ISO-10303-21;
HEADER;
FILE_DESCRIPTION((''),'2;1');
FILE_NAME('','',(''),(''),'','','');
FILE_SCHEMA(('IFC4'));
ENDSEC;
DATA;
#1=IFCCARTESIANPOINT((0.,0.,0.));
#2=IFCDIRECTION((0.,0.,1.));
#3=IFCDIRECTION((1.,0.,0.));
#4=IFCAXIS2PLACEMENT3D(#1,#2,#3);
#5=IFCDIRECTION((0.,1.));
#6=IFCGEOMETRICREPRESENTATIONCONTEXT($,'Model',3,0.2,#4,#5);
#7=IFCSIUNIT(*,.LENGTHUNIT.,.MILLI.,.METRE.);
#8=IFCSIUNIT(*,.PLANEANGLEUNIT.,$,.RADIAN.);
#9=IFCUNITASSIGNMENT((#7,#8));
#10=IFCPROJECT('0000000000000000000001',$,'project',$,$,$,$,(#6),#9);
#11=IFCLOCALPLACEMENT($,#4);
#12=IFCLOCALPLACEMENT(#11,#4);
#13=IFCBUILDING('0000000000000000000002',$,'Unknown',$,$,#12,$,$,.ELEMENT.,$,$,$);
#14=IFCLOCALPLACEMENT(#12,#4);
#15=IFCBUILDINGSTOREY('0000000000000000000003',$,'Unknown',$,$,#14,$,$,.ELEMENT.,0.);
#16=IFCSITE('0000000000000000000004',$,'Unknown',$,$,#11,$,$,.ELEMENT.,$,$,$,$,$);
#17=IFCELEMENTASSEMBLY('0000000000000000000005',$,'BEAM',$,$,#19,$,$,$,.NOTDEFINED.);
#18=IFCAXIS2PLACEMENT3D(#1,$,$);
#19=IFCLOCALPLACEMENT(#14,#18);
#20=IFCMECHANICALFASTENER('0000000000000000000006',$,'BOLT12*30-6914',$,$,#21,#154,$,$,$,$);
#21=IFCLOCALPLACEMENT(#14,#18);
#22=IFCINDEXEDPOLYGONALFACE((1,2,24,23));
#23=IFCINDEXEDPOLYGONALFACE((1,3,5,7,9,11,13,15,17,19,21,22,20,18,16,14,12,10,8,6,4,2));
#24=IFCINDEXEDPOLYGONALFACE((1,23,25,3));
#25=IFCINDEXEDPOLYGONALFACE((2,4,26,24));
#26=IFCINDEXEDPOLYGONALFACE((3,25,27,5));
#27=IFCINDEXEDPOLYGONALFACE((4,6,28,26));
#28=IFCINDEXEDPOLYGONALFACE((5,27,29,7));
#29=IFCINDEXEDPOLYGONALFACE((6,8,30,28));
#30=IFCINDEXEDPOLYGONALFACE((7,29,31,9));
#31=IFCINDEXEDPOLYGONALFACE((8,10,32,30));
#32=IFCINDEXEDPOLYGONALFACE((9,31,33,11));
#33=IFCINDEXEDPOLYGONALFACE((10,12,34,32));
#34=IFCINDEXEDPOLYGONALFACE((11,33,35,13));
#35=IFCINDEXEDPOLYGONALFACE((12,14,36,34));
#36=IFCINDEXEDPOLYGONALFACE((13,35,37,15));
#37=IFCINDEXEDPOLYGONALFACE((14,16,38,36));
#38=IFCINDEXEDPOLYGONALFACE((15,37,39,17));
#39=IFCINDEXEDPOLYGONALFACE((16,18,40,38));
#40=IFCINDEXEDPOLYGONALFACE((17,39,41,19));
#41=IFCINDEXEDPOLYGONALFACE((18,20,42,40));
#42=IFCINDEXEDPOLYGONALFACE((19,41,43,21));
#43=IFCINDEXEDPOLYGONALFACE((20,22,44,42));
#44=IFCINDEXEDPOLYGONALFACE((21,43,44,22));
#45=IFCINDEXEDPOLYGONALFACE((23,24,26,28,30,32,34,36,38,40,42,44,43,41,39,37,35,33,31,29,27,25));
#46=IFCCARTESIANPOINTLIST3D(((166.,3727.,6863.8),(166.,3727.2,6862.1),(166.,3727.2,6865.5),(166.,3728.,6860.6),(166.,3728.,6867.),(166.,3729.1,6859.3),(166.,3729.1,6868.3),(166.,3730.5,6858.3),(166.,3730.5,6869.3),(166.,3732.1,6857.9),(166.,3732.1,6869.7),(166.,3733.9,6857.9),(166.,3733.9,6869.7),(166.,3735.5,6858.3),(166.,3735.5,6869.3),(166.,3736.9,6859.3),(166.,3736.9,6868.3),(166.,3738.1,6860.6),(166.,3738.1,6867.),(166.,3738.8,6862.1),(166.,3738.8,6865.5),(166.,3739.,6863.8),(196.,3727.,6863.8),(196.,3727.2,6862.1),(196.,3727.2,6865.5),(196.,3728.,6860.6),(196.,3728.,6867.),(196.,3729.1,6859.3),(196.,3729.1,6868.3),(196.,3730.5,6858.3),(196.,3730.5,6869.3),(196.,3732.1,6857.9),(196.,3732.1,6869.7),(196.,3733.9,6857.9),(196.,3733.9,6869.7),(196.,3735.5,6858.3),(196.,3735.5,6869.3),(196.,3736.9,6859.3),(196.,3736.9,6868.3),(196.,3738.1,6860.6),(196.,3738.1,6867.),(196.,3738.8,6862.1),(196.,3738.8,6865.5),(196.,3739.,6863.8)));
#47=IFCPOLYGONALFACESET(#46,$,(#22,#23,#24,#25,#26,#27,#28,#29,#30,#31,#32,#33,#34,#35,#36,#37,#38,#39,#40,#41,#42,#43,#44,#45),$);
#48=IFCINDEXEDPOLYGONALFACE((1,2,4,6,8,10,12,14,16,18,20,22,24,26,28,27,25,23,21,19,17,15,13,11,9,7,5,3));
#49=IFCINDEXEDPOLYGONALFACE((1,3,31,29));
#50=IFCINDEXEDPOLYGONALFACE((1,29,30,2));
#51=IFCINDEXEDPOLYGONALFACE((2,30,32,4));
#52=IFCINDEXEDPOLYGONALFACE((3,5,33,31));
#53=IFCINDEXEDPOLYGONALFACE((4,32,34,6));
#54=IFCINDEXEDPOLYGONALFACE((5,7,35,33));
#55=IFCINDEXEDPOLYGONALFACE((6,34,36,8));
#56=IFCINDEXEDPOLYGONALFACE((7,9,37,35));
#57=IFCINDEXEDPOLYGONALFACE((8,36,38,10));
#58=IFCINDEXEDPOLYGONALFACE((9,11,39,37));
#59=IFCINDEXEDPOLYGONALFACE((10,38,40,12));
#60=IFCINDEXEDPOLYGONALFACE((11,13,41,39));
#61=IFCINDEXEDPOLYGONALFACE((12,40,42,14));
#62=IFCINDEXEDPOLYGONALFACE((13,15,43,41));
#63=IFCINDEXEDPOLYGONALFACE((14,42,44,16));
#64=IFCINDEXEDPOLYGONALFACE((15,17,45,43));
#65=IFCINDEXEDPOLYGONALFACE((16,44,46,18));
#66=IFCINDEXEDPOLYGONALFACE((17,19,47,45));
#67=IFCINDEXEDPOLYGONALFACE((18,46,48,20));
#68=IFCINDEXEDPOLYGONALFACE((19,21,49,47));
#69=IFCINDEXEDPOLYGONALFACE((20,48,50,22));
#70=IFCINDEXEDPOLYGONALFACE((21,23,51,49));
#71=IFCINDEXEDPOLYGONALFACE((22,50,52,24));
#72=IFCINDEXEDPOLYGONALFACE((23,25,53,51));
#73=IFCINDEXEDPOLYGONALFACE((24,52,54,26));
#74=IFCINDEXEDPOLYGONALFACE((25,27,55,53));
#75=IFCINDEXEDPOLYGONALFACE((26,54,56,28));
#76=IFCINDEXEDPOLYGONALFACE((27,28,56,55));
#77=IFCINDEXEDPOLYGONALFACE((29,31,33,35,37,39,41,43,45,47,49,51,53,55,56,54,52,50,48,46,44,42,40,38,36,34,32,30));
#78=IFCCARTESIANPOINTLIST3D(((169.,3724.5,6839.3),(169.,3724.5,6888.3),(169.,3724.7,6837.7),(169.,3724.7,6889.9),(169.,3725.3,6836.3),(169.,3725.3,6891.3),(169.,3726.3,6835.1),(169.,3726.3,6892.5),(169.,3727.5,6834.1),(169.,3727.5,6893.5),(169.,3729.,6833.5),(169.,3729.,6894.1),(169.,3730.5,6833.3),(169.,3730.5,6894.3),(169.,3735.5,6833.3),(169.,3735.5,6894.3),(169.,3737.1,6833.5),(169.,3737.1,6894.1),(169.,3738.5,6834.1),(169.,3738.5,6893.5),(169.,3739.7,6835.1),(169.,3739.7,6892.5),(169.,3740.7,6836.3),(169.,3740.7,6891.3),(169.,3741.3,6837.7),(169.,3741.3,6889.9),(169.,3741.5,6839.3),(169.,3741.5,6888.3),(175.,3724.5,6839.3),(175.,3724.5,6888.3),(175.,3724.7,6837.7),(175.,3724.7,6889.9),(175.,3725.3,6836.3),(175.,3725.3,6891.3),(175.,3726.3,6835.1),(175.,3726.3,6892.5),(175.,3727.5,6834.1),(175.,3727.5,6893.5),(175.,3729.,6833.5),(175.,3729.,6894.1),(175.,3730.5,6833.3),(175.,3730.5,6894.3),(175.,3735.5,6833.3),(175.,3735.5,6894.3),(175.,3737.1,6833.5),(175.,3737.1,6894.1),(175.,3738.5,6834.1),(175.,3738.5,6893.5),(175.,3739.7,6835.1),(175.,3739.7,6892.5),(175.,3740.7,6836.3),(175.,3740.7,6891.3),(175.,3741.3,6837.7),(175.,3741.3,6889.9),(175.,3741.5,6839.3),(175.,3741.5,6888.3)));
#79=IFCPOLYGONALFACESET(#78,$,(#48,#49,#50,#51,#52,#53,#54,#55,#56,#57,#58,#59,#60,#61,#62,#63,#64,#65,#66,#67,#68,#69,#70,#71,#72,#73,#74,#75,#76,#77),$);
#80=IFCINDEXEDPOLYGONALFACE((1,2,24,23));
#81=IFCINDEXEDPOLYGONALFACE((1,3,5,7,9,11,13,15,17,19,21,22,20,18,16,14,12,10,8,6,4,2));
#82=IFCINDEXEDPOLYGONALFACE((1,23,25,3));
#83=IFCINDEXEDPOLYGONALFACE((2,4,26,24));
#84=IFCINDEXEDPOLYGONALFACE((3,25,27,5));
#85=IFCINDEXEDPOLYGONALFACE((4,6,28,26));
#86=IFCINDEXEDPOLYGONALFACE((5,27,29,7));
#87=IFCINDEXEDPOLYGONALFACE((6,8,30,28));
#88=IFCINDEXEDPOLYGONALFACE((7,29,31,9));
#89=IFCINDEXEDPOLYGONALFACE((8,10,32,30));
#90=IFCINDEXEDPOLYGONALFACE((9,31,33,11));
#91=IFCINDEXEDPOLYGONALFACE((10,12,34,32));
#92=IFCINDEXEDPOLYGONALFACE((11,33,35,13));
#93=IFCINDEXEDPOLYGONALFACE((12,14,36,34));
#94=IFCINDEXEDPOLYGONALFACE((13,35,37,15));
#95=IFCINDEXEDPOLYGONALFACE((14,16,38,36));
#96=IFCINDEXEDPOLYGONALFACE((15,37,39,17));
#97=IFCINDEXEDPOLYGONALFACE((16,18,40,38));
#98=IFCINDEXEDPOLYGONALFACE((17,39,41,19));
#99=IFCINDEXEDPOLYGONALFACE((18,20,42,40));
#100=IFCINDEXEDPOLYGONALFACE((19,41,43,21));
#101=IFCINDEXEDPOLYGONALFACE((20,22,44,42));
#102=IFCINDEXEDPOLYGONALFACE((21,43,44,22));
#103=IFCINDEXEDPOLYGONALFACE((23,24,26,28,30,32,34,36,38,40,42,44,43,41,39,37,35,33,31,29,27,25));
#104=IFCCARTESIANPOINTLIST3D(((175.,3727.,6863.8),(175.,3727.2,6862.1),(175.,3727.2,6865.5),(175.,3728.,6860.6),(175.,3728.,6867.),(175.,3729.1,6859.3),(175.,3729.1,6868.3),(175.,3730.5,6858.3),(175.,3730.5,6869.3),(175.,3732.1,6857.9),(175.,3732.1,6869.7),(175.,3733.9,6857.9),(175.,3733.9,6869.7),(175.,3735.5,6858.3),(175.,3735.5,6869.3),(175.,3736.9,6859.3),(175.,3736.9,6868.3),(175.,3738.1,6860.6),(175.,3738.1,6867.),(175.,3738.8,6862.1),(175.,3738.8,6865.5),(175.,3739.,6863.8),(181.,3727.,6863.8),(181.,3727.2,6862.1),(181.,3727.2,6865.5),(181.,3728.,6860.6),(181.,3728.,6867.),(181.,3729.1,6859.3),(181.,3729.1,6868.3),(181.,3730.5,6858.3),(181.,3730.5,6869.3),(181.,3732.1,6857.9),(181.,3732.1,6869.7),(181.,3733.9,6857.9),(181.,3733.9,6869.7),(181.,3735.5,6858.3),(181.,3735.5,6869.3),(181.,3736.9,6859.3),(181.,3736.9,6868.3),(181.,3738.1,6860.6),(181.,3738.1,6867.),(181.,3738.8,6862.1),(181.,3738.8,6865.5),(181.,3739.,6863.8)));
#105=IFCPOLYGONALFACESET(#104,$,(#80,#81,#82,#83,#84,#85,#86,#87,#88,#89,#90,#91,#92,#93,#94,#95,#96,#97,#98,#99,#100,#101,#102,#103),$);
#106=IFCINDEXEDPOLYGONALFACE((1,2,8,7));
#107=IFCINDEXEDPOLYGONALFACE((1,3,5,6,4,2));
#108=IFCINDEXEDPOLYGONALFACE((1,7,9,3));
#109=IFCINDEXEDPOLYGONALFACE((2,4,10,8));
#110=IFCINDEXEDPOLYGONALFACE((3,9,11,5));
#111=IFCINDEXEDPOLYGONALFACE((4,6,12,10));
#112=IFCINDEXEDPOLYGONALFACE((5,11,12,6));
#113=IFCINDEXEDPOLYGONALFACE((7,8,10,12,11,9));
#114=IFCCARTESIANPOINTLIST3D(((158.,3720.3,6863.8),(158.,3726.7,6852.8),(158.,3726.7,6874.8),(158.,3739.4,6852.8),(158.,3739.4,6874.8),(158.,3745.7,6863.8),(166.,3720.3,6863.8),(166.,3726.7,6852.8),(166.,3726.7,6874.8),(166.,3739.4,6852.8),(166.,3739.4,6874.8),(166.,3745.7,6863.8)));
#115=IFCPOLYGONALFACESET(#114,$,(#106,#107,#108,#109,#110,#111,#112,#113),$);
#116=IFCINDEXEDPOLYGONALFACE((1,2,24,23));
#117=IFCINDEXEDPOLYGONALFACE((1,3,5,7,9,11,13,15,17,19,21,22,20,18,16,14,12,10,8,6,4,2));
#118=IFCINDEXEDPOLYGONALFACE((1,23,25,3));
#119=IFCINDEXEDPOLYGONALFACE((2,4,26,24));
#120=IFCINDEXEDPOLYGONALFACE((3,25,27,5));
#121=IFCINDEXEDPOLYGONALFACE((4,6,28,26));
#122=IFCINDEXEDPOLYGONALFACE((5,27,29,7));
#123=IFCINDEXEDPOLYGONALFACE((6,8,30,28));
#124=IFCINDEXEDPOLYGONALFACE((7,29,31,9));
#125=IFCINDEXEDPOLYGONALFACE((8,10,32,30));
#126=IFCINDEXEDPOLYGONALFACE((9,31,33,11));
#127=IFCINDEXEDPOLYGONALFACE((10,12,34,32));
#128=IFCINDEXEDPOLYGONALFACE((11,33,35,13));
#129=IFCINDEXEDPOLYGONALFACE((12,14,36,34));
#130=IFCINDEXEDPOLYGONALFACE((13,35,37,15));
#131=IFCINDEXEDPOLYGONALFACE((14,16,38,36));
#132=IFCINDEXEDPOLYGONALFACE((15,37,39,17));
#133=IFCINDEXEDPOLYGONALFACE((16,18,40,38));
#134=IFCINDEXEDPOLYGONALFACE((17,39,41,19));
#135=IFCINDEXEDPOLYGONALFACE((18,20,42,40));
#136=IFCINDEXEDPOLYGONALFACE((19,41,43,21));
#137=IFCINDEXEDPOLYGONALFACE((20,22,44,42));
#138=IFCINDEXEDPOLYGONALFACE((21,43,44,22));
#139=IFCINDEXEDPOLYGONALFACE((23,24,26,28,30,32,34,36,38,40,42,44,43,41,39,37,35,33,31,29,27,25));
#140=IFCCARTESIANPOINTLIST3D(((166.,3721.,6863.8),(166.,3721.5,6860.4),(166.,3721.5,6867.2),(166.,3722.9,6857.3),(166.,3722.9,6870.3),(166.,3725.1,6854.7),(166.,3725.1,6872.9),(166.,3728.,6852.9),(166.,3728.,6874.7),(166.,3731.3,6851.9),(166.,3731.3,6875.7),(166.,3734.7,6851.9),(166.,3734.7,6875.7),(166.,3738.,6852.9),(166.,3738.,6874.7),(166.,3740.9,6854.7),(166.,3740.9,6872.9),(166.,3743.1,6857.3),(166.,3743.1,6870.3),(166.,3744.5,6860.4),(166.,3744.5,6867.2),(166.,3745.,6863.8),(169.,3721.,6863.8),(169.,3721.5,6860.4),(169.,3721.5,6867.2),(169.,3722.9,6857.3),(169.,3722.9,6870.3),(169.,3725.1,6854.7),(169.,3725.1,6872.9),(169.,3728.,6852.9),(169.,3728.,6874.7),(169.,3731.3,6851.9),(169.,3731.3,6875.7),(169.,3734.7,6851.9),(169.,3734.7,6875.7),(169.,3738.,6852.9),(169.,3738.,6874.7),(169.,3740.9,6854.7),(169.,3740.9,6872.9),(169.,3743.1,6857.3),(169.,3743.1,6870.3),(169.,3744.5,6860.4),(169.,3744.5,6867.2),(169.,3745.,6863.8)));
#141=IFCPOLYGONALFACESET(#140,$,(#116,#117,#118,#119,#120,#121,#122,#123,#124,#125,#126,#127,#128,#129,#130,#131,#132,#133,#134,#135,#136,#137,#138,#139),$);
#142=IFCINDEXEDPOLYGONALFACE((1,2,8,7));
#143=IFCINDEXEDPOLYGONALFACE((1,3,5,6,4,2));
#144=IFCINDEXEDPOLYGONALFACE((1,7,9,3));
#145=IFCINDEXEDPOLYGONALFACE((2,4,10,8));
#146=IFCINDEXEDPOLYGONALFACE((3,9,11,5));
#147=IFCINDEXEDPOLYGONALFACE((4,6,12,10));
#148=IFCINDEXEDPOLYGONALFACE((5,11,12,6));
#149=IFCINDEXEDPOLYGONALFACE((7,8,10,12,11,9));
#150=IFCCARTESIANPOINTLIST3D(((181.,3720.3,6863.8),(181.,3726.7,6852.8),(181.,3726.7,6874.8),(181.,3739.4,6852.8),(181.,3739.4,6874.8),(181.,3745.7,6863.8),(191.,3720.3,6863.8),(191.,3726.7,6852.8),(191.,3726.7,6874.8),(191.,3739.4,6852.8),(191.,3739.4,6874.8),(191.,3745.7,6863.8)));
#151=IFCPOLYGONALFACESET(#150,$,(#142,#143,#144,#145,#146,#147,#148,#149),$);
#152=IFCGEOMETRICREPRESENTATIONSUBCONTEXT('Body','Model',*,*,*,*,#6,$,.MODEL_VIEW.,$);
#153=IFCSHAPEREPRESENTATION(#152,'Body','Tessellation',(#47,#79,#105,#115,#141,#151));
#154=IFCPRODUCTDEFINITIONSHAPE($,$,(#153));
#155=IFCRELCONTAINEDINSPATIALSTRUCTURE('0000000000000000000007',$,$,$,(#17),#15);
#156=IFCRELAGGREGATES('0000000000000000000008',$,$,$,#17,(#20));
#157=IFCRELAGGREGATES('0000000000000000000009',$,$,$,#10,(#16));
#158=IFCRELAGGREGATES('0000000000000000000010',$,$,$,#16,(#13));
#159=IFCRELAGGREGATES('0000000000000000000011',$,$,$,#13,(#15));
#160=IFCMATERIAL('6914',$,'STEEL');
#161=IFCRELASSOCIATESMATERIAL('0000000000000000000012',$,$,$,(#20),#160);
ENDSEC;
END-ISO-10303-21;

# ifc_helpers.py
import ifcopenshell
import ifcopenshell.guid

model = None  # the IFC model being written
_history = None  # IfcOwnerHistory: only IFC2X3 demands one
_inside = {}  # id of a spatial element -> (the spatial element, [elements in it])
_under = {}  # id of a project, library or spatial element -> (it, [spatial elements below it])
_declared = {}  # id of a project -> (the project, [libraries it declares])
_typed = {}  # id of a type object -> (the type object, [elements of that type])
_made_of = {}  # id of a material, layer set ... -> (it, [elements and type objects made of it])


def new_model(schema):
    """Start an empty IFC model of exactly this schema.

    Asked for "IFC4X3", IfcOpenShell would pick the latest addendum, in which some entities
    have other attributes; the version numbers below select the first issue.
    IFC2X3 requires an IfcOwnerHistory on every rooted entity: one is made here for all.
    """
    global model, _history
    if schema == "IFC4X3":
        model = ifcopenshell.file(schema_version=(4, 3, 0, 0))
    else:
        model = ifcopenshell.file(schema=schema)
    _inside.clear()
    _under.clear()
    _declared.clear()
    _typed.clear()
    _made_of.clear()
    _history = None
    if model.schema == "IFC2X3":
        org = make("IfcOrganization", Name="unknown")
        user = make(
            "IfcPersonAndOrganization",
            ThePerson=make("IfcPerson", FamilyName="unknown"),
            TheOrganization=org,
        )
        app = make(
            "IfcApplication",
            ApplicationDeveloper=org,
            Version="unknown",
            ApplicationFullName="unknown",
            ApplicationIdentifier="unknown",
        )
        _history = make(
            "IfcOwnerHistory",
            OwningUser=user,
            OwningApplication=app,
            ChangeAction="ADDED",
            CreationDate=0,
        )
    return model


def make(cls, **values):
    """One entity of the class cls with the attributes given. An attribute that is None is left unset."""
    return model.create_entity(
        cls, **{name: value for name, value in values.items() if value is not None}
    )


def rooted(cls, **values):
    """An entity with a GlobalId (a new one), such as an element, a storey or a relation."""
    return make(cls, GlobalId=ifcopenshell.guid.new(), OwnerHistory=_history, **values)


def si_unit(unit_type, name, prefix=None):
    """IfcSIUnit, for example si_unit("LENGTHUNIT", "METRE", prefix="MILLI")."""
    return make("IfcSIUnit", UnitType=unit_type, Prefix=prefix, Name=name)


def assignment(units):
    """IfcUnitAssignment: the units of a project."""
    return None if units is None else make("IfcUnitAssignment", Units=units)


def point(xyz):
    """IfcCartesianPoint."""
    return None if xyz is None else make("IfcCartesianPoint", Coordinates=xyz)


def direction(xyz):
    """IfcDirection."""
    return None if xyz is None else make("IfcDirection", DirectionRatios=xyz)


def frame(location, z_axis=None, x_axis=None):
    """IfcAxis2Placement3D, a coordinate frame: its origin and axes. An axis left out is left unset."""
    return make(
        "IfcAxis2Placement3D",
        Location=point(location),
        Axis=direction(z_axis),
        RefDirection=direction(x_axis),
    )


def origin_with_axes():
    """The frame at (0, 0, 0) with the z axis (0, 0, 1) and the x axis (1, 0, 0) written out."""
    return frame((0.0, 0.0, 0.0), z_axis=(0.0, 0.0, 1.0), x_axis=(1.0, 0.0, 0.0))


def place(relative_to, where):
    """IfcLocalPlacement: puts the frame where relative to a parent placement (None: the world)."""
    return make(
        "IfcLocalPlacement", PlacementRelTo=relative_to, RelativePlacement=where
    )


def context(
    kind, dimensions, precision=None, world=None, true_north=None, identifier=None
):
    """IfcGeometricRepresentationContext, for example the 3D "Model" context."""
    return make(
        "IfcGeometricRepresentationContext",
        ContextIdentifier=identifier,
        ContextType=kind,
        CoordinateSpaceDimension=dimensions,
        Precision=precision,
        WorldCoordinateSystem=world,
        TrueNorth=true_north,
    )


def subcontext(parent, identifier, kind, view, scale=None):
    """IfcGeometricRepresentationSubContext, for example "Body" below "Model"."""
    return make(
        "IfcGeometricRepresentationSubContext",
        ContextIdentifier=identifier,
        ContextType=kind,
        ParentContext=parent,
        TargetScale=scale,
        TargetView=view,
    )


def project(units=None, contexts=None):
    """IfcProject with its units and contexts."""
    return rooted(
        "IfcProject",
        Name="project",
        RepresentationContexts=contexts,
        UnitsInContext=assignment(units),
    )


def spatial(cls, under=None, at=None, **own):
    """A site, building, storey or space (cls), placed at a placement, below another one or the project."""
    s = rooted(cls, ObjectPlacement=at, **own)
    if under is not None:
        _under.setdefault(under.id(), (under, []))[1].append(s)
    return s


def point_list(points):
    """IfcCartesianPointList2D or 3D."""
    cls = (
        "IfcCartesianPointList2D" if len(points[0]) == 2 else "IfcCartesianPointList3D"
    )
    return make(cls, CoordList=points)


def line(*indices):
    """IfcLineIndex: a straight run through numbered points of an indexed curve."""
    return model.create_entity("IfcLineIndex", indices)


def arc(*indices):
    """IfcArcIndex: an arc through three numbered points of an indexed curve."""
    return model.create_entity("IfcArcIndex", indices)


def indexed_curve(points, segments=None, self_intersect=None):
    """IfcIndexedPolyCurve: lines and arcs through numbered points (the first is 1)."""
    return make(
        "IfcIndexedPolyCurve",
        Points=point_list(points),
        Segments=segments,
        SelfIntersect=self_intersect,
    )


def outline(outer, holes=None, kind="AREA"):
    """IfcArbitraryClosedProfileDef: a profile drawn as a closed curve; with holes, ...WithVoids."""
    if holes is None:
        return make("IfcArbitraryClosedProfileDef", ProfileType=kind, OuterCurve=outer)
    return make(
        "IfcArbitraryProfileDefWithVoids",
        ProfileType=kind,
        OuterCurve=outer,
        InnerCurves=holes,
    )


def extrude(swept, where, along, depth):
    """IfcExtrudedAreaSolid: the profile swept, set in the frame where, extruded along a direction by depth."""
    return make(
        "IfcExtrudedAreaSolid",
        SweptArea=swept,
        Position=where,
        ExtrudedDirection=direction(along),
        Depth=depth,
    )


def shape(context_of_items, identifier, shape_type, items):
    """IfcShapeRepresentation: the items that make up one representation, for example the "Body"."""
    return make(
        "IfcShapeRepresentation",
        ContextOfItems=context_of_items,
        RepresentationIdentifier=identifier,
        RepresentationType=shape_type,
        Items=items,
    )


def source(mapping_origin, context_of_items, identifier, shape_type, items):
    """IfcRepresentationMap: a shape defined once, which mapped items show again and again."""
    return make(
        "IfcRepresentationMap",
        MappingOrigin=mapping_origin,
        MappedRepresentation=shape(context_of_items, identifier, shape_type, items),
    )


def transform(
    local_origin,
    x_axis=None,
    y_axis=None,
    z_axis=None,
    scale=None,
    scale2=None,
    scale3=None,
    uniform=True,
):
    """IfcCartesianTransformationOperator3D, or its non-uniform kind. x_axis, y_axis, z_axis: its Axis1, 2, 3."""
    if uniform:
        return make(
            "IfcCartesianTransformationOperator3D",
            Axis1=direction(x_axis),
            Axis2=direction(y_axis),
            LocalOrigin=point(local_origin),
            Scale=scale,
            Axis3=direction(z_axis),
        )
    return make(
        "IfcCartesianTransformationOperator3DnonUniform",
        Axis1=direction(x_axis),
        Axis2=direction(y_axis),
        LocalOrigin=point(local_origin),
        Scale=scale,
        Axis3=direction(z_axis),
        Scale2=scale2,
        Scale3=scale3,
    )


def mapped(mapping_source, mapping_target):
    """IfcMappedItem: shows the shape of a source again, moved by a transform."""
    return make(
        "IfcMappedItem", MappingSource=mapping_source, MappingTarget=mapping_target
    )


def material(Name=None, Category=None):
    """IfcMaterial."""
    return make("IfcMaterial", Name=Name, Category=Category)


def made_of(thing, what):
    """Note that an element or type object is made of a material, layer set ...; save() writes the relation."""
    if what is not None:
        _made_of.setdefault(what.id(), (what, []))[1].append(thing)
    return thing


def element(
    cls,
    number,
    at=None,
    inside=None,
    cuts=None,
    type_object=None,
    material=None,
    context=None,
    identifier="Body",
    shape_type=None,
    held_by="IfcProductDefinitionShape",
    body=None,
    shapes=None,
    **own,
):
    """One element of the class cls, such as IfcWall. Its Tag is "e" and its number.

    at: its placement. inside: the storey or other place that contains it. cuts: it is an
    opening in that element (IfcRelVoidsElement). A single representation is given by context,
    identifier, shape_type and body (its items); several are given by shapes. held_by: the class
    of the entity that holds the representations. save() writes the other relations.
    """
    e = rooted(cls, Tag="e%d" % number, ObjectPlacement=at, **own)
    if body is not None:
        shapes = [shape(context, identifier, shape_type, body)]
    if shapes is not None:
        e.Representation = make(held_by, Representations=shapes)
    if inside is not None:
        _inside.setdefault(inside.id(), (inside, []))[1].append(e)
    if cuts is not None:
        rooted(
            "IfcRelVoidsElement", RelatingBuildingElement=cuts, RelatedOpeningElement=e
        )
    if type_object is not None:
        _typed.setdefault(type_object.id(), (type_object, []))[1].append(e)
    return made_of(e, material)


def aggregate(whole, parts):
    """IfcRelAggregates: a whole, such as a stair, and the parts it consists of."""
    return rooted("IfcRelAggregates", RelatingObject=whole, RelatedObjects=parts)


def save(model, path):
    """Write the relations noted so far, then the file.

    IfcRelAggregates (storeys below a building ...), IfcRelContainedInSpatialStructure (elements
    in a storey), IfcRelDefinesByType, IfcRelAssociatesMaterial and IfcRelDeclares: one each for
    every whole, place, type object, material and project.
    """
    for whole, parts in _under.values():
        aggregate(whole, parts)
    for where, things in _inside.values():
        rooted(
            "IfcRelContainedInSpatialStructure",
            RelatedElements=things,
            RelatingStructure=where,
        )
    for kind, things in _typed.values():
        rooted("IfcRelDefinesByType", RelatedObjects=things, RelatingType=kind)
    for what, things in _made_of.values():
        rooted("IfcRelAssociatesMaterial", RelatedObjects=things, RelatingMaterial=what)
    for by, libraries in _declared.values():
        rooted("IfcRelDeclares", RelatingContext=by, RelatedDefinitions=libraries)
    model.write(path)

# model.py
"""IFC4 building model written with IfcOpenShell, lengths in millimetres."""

from ifc_helpers import new_model, si_unit, direction, frame, origin_with_axes, place, context, subcontext, project, spatial, line, arc, indexed_curve, outline, extrude, source, transform, mapped, material, element, aggregate, save


model = new_model("IFC4")

# Units and contexts
model_context = context("Model", 3, precision=0.2, world=origin_with_axes(), true_north=direction((0.0, 1.0)))
body_context = subcontext(model_context, "Body", "Model", "MODEL_VIEW")
ifc_project = project(units=[si_unit("LENGTHUNIT", "METRE", prefix="MILLI"), si_unit("PLANEANGLEUNIT", "RADIAN")], contexts=[model_context])

# Site, building, storey
site_placement = place(None, origin_with_axes())
site = spatial("IfcSite", under=ifc_project, at=site_placement, Name="Unknown", CompositionType="ELEMENT")
building_placement = place(site_placement, origin_with_axes())
building = spatial("IfcBuilding", under=site, at=building_placement, Name="Unknown", CompositionType="ELEMENT")
storey_placement = place(building_placement, origin_with_axes())
storey = spatial("IfcBuildingStorey", under=building, at=storey_placement, Name="Unknown", CompositionType="ELEMENT", Elevation=0.0)

# Element assembly
assembly_1_placement = place(storey_placement, frame((175.5, 3720.0, 6980.0), z_axis=(0.0, -1.0, 0.000002), x_axis=(1.0, 0.0, 0.0)))
assembly_1 = element("IfcElementAssembly", 1, at=assembly_1_placement, inside=storey, Name="BEAM", PredefinedType="NOTDEFINED")

# Mechanical fastener
ifc_material_1 = material(Name="6914", Category="STEEL")
shared_shape_1 = source(origin_with_axes(), body_context, "Body", "SweptSolid", [
    extrude(outline(indexed_curve([(6.0, 0.0), (0.0, 6.0), (-6.0, 0.0), (0.0, -6.0)], segments=[arc(1, 2, 3), arc(3, 4, 1)])), frame((0.0, 0.0, 9.0), z_axis=(0.0, -0.000002, -1.0), x_axis=(0.0, 1.0, 0.0)), (0.0, 0.0, 1.0), 30.0),
    extrude(outline(indexed_curve([(-2.5, 30.5), (2.5, 30.5), (2.5, 30.5), (6.7, 28.7), (8.5, 24.5), (8.5, -24.5), (6.7, -28.7), (2.5, -30.5), (-2.5, -30.5), (-3.0, -30.5), (-8.5, -24.5), (-8.5, 24.5), (-6.7, 28.7)], segments=[line(1, 2, 3), arc(3, 4, 5), line(5, 6), arc(6, 7, 8), line(8, 9), arc(9, 10, 11), line(11, 12), arc(12, 13, 1)])), frame((0.0, 0.0, 6.0), z_axis=(0.0, -0.000002, -1.0), x_axis=(0.0, 1.0, 0.0)), (0.0, 0.0, 1.0), 6.0),
    extrude(outline(indexed_curve([(6.0, 0.0), (0.0, 6.0), (-6.0, 0.0), (0.0, -6.0)], segments=[arc(1, 2, 3), arc(3, 4, 1)])), frame((0.0, 0.0, 0.0), z_axis=(0.0, -0.000002, -1.0), x_axis=(0.0, 1.0, 0.0)), (0.0, 0.0, 1.0), 6.0),
    extrude(outline(indexed_curve([(12.7, 0.0), (6.4, 11.0), (-6.4, 11.0), (-12.7, 0.0), (-6.4, -11.0), (6.4, -11.0)], segments=[line(1, 2, 3, 4, 5, 6, 1)])), frame((0.0, 0.0, 17.0), z_axis=(0.0, -0.000002, -1.0), x_axis=(0.0, 1.0, 0.0)), (0.0, 0.0, 1.0), 8.0),
    extrude(outline(indexed_curve([(12.0, 0.0), (0.0, 12.0), (-12.0, 0.0), (0.0, -12.0)], segments=[arc(1, 2, 3), arc(3, 4, 1)])), frame((0.0, 0.0, 9.0), z_axis=(0.0, -0.000002, -1.0), x_axis=(0.0, 1.0, 0.0)), (0.0, 0.0, 1.0), 3.0),
    extrude(outline(indexed_curve([(12.7, 0.0), (6.4, 11.0), (-6.4, 11.0), (-12.7, 0.0), (-6.4, -11.0), (6.4, -11.0)], segments=[line(1, 2, 3, 4, 5, 6, 1)])), frame((0.0, 0.0, -6.0), z_axis=(0.0, -0.000002, -1.0), x_axis=(0.0, 1.0, 0.0)), (0.0, 0.0, 1.0), 10.0),
])
mechanical_fastener_1_placement = place(assembly_1_placement, frame((-0.5, -116.2, -13.0), z_axis=(-1.0, 0.0, 0.0), x_axis=(0.0, 1.0, 0.0)))
mechanical_fastener_1 = element("IfcMechanicalFastener", 2, at=mechanical_fastener_1_placement, material=ifc_material_1, Name="BOLT12*30-6914", context=body_context, shape_type="MappedRepresentation", body=[
    mapped(shared_shape_1, transform((0.0, 0.0, 0.0))),
])
aggregate(assembly_1, [mechanical_fastener_1])

save(model, "model.ifc")
